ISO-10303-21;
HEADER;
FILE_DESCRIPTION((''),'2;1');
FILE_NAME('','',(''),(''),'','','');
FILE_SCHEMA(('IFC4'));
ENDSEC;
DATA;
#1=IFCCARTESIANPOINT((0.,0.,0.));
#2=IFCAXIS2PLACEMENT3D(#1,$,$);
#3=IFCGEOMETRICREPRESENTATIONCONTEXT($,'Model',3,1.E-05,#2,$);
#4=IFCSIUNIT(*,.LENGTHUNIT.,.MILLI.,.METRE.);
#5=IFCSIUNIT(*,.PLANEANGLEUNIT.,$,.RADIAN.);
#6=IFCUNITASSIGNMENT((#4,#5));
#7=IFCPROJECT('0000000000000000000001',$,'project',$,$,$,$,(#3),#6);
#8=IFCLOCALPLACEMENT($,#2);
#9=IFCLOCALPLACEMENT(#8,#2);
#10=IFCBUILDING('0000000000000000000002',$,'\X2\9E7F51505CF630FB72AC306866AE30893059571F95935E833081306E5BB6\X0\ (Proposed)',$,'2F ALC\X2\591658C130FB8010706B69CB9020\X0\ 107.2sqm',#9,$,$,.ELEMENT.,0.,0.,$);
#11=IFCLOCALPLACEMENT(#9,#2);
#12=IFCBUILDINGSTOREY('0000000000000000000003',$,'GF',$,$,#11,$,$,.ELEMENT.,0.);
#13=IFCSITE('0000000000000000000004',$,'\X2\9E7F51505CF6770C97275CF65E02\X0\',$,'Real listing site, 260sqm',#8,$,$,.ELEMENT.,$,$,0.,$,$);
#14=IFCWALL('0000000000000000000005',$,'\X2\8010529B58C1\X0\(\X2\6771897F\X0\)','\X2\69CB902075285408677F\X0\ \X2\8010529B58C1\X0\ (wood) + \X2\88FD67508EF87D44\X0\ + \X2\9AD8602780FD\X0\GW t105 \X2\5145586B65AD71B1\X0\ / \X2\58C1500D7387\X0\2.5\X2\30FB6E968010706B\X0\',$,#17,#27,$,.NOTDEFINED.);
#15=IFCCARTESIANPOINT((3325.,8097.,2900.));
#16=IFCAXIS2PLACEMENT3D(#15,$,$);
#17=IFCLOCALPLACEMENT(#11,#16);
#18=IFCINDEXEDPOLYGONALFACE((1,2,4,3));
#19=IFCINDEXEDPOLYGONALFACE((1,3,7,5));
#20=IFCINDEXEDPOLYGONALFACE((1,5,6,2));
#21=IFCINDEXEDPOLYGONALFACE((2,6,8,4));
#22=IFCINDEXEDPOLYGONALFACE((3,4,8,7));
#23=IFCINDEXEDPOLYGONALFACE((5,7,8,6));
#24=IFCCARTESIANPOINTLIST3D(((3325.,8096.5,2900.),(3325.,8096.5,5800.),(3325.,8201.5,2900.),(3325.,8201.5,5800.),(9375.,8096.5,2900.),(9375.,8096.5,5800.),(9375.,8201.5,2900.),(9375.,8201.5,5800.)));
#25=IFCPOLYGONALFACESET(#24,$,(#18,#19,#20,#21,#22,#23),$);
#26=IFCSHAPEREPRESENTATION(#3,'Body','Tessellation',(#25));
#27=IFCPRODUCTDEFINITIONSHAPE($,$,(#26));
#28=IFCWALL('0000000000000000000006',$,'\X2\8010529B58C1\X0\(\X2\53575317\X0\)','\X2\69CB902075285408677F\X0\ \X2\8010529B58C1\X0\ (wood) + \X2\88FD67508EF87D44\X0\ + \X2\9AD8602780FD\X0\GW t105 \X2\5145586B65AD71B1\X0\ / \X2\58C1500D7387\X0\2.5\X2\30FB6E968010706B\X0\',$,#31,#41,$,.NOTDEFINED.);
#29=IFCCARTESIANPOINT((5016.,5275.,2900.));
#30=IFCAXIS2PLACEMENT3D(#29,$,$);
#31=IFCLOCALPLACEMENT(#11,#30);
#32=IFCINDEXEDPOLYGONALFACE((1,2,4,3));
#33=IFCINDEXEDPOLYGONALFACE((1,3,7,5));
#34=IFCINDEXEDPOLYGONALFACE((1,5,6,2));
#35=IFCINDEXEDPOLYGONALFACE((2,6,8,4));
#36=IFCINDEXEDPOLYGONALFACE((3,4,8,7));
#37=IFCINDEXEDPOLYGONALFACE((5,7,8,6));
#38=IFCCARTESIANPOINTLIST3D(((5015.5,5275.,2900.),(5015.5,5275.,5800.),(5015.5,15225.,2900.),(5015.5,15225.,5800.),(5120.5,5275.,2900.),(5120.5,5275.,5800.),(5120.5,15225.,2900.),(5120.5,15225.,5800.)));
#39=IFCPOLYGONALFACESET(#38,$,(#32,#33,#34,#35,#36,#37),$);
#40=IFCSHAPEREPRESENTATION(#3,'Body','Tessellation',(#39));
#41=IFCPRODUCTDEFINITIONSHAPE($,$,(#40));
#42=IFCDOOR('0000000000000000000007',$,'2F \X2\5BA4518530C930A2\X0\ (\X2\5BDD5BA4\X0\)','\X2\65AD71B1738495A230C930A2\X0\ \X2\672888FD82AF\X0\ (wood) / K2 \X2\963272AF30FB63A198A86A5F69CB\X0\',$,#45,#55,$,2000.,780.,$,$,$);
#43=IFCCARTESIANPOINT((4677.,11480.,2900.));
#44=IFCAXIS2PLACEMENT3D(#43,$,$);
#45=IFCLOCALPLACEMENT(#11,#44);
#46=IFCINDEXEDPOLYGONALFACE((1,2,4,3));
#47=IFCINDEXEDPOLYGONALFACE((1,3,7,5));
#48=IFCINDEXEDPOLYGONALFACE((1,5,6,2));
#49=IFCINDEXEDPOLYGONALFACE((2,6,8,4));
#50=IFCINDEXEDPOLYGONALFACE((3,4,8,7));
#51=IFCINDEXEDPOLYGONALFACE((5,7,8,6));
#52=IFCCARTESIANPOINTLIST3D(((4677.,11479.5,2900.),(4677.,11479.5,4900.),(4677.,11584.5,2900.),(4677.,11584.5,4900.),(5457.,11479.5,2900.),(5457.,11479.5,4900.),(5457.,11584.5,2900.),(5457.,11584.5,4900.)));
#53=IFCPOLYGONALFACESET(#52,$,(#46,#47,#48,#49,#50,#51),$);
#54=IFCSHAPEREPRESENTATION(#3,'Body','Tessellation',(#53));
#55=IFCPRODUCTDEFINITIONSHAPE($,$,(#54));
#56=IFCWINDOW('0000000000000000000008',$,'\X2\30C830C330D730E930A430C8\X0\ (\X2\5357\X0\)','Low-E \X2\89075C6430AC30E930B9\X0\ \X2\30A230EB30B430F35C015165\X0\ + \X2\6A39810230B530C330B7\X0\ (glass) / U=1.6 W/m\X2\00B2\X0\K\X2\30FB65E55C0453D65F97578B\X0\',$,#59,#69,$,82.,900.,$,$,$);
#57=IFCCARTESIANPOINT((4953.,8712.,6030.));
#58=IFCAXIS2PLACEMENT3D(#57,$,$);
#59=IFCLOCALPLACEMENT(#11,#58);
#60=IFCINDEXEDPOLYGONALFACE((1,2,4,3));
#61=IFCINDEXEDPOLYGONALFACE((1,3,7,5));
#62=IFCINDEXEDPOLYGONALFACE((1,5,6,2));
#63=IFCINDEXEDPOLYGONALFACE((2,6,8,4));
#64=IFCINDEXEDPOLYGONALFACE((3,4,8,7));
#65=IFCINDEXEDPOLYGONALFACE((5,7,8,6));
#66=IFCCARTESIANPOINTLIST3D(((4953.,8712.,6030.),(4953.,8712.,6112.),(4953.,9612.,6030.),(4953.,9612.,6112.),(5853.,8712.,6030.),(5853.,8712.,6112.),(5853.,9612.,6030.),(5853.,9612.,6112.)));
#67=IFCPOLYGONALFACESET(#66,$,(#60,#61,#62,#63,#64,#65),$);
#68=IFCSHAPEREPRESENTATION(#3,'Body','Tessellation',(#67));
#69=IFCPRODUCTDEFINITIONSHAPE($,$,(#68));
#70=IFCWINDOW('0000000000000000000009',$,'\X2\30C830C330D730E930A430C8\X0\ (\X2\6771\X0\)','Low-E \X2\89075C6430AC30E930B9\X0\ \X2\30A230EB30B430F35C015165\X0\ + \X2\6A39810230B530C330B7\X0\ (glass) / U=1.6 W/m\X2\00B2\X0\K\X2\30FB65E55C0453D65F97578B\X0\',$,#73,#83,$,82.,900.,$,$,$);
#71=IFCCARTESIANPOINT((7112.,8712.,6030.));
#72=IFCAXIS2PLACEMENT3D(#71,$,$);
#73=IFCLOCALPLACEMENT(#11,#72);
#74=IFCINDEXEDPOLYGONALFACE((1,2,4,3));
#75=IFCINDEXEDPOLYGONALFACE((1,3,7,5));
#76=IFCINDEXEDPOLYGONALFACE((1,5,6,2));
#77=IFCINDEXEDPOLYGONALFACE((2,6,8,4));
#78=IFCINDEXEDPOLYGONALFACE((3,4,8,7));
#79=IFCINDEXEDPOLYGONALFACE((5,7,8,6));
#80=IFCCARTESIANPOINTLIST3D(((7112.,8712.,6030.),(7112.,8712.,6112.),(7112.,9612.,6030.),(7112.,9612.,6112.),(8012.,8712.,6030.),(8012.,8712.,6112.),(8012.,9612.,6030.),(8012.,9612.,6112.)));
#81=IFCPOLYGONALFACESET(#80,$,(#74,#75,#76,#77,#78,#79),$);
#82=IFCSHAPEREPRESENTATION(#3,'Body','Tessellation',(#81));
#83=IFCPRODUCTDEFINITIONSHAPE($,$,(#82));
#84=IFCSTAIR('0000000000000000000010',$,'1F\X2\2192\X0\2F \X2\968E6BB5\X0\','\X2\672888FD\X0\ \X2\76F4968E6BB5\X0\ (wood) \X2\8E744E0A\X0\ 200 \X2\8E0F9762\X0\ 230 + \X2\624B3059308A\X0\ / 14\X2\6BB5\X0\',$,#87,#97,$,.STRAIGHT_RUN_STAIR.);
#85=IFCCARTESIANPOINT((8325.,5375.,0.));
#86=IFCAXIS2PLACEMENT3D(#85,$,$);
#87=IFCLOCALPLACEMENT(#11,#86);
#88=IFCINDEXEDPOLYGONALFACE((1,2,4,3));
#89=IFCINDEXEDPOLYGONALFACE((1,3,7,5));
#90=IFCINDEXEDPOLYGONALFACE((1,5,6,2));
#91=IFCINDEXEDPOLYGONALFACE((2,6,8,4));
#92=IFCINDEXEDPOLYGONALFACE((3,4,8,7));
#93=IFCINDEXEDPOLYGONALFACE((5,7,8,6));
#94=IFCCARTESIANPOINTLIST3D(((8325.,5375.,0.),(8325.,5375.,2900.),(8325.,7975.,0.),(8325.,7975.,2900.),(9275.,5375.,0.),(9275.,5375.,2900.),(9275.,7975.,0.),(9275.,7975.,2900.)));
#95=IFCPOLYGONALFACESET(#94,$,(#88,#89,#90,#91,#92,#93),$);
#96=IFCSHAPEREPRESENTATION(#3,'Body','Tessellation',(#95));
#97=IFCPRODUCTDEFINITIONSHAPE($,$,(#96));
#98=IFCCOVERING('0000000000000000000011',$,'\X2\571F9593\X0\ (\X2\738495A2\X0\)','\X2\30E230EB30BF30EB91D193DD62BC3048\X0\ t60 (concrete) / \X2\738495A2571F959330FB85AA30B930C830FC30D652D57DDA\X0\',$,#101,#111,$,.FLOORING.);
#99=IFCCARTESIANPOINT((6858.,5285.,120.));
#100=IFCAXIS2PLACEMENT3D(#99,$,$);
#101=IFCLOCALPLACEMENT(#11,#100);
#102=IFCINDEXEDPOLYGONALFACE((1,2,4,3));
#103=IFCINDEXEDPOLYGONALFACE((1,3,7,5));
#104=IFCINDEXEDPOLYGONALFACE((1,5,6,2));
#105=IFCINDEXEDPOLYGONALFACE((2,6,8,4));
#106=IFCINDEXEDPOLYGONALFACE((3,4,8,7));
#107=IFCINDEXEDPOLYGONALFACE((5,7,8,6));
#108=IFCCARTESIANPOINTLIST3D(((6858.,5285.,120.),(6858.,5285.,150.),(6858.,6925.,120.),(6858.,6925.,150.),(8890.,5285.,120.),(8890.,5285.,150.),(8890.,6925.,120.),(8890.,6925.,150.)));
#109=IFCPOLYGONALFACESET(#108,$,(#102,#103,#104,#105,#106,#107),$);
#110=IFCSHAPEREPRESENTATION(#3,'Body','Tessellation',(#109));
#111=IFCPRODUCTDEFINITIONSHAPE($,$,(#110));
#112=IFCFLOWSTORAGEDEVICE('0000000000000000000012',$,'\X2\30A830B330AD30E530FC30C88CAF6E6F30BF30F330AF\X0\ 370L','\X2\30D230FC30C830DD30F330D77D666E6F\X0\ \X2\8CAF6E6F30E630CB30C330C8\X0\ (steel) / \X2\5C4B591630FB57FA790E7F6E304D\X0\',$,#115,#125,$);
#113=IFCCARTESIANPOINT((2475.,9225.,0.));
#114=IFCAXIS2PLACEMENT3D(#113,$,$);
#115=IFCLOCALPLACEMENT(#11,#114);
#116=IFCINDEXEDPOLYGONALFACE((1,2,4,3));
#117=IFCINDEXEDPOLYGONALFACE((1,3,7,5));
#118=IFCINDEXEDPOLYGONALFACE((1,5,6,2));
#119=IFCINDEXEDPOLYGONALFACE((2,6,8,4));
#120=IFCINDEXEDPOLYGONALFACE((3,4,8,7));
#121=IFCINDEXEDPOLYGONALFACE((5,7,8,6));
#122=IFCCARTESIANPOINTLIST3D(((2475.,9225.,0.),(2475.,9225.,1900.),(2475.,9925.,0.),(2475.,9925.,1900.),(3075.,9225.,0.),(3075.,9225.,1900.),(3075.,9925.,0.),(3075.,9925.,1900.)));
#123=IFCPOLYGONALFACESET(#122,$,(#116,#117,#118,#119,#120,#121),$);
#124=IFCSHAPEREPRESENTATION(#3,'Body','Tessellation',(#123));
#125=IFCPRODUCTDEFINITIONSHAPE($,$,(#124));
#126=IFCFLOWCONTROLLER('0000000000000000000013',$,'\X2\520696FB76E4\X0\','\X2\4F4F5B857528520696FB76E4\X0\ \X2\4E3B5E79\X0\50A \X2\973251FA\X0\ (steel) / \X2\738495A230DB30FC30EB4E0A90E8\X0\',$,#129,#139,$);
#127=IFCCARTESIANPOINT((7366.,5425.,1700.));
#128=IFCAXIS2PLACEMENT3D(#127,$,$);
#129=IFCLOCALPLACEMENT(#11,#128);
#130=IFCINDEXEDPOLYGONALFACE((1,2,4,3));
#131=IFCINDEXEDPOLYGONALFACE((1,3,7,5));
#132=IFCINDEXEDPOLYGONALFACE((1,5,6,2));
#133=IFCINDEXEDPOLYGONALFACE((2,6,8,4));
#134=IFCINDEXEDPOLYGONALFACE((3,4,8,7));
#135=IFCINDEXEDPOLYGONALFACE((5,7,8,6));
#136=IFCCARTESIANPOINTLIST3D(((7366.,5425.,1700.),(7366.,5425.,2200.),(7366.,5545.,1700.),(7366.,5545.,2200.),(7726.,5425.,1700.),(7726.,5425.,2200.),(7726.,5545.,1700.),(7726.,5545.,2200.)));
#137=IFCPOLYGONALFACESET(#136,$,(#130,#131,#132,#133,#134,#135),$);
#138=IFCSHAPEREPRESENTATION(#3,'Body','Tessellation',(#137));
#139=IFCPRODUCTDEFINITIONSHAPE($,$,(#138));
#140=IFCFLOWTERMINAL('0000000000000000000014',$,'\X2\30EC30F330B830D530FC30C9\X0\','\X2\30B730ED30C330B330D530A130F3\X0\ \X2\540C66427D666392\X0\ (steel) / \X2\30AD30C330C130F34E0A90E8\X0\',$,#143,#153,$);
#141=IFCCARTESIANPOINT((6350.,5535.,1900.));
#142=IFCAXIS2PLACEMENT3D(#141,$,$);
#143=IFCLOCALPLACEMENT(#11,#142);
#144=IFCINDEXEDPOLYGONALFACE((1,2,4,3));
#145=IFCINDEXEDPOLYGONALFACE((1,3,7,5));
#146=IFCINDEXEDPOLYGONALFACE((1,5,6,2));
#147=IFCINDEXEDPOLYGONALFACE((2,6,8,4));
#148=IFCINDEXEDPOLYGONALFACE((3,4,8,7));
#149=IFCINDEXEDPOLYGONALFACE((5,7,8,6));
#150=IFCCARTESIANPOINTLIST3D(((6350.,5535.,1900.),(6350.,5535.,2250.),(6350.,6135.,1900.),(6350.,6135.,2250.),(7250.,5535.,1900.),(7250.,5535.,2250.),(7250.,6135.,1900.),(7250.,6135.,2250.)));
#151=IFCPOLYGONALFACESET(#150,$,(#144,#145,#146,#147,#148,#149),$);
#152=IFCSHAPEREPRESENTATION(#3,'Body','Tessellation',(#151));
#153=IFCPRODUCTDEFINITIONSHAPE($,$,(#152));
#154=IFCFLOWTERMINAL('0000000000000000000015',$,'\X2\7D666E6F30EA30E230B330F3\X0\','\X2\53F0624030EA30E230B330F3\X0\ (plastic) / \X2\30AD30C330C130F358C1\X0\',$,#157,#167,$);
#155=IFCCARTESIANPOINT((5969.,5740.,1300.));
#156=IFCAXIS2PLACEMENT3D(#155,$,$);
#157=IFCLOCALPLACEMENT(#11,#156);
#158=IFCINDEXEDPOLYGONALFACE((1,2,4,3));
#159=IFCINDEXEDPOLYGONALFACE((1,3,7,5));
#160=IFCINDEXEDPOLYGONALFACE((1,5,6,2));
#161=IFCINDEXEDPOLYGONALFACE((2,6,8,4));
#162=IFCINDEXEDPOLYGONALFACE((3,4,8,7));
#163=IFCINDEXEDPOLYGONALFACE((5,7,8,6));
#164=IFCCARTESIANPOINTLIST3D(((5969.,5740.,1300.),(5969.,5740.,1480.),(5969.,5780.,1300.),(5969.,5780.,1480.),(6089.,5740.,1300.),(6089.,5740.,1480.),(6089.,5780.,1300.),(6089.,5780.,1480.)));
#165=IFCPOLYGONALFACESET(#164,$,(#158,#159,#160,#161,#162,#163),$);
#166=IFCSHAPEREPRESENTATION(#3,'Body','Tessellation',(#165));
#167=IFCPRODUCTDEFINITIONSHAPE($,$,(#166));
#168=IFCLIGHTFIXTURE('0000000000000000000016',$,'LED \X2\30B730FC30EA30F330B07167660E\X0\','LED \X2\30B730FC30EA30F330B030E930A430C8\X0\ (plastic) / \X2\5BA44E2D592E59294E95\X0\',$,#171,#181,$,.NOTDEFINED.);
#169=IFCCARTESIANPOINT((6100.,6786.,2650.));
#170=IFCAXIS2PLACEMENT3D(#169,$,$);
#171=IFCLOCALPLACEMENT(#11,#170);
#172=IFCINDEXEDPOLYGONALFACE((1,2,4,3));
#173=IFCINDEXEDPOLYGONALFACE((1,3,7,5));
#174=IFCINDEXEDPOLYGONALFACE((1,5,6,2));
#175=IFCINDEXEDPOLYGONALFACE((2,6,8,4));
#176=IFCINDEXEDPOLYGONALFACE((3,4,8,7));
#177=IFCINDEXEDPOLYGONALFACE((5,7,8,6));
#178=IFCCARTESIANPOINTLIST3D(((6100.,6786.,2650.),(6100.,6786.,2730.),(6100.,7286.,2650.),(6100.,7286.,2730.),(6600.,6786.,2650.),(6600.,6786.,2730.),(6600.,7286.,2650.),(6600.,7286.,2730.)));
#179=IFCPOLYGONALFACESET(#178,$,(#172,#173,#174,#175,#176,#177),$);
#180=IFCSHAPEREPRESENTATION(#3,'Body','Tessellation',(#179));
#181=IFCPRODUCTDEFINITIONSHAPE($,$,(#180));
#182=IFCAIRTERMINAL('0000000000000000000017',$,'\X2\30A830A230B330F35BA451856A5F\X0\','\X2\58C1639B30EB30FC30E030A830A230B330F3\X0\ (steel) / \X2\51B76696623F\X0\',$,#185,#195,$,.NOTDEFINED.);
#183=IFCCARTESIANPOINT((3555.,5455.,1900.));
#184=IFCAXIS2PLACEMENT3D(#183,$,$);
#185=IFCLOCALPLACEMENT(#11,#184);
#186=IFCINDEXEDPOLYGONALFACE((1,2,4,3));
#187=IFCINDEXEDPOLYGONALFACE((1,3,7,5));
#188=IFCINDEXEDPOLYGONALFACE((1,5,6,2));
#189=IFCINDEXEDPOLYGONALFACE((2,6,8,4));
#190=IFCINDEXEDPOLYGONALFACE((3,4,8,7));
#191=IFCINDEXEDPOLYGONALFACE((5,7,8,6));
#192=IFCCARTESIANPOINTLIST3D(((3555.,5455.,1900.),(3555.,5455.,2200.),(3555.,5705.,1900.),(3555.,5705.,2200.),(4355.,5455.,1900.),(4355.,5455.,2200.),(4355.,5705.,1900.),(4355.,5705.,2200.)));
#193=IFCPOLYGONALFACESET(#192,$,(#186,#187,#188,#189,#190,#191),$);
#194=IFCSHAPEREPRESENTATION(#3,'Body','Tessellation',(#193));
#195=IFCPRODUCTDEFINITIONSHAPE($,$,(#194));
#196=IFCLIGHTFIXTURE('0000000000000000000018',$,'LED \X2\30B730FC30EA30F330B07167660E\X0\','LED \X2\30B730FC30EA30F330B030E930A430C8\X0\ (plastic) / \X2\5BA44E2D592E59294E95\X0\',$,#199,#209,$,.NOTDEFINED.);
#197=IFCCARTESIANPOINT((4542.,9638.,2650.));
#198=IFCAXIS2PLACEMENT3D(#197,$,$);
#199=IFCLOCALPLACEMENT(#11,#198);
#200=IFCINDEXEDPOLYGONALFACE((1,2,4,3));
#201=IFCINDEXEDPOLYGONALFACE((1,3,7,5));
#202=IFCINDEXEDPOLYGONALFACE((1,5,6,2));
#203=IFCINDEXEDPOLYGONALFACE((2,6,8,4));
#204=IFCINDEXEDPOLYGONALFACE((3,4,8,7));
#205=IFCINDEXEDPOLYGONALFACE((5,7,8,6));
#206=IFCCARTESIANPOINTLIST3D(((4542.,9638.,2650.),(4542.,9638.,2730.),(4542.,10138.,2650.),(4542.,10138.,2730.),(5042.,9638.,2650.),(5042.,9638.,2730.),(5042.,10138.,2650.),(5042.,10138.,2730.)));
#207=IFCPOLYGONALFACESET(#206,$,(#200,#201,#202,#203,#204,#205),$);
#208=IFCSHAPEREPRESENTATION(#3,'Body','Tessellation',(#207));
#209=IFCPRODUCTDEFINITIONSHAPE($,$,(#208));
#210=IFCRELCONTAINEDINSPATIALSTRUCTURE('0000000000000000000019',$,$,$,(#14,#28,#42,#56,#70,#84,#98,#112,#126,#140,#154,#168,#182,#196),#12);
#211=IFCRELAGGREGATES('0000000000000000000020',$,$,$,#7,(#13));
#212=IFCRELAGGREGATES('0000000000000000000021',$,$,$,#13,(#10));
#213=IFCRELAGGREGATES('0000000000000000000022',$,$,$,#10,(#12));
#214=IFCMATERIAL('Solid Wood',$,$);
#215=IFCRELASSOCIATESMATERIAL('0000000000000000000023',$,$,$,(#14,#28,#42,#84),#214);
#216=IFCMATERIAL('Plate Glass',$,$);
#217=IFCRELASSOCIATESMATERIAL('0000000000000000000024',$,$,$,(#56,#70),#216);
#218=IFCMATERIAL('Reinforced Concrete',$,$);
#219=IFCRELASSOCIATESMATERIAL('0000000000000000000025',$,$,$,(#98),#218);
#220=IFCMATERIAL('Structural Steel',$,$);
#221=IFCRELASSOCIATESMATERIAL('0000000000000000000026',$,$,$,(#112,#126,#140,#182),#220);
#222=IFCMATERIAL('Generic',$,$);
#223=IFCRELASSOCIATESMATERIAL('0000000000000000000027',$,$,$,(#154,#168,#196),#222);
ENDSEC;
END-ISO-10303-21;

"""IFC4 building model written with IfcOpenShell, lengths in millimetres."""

from ifc_helpers import new_model, si_unit, frame, frame_2d, origin, place, context, project, spatial, rectangle, extrude, material, element, fill, save


model = new_model("IFC4")

# Units and contexts
model_context = context("Model", 3, precision=1e-05, world=origin())
ifc_project = project(units=[si_unit("LENGTHUNIT", "METRE", prefix="MILLI"), si_unit("PLANEANGLEUNIT", "RADIAN")], contexts=[model_context])

# Site, building, storey
site_placement = place(None, origin())
site = spatial("IfcSite", under=ifc_project, at=site_placement, Name="鹿児島県霧島市", ObjectType="Real listing site, 260sqm", CompositionType="ELEMENT", RefElevation=0.0)
building_placement = place(site_placement, origin())
building = spatial("IfcBuilding", under=site, at=building_placement, Name="鹿児島・犬と暮らす土間広めの家 (Proposed)", ObjectType="2F ALC外壁・耐火構造 107.2sqm", CompositionType="ELEMENT", ElevationOfRefHeight=0.0, ElevationOfTerrain=0.0)
storey_placement = place(building_placement, origin())
storey = spatial("IfcBuildingStorey", under=building, at=storey_placement, Name="GF", CompositionType="ELEMENT", Elevation=0.0)

# Shared definitions
ifc_material_1 = material(Name="Solid Wood")

# Wall
wall_1_placement = place(storey_placement, frame((3325.0, 8097.0, 2900.0)))
element("IfcWall", 1, at=wall_1_placement, inside=storey, material=ifc_material_1, Name="耐力壁(東西)", Description="構造用合板 耐力壁 (wood) + 製材軸組 + 高性能GW t105 充填断熱 / 壁倍率2.5・準耐火", PredefinedType="NOTDEFINED", context=model_context, shape_type="SweptSolid", body=[
    extrude(rectangle(XDim=6050.0, YDim=105.0, at=frame_2d((3025.0, 52.0))), frame((3325.0, 8097.0, 2900.0)), (0.0, 0.0, 1.0), 2900.0),
])

# Wall, opening, door
wall_2_placement = place(storey_placement, frame((5016.0, 5275.0, 2900.0)))
wall_2 = element("IfcWall", 2, at=wall_2_placement, inside=storey, material=ifc_material_1, Name="耐力壁(南北)", Description="構造用合板 耐力壁 (wood) + 製材軸組 + 高性能GW t105 充填断熱 / 壁倍率2.5・準耐火", PredefinedType="NOTDEFINED", context=model_context, shape_type="SweptSolid", body=[
    extrude(rectangle(XDim=105.0, YDim=9950.0, at=frame_2d((52.0, 4975.0))), frame((5016.0, 5275.0, 2900.0)), (0.0, 0.0, 1.0), 2900.0),
])
opening_placement = place(storey_placement, frame((4677.0, 11480.0, 2900.0)))
opening = element("IfcOpeningElement", 3, at=opening_placement, cuts=wall_2, PredefinedType="NOTDEFINED", context=model_context, shape_type="SweptSolid", body=[
    extrude(rectangle(XDim=780.0, YDim=105.0, at=frame_2d((390.0, 52.0))), frame((4677.0, 11480.0, 2900.0)), (0.0, 0.0, 1.0), 2000.0),
])
door_placement = place(storey_placement, frame((4677.0, 11480.0, 2900.0)))
door = element("IfcDoor", 4, at=door_placement, inside=storey, material=ifc_material_1, Name="2F 室内ドア (寝室)", Description="断熱玄関ドア 木製芯 (wood) / K2 防犯・採風機構", OverallHeight=2000.0, OverallWidth=780.0, context=model_context, shape_type="SweptSolid", body=[
    extrude(rectangle(XDim=780.0, YDim=105.0, at=frame_2d((390.0, 52.0))), frame((4677.0, 11480.0, 2900.0)), (0.0, 0.0, 1.0), 2000.0),
])
fill(opening, door)

# Windows
ifc_material_2 = material(Name="Plate Glass")
window_1_placement = place(storey_placement, frame((4953.0, 8712.0, 6030.0)))
element("IfcWindow", 5, at=window_1_placement, inside=storey, material=ifc_material_2, Name="トップライト (南)", Description="Low-E 複層ガラス アルゴン封入 + 樹脂サッシ (glass) / U=1.6 W/m²K・日射取得型", OverallHeight=82.0, OverallWidth=900.0, context=model_context, shape_type="SweptSolid", body=[
    extrude(rectangle(XDim=900.0, YDim=900.0, at=frame_2d((450.0, 450.0))), frame((4953.0, 8712.0, 6030.0)), (0.0, 0.0, 1.0), 82.0),
])
window_2_placement = place(storey_placement, frame((7112.0, 8712.0, 6030.0)))
element("IfcWindow", 6, at=window_2_placement, inside=storey, material=ifc_material_2, Name="トップライト (東)", Description="Low-E 複層ガラス アルゴン封入 + 樹脂サッシ (glass) / U=1.6 W/m²K・日射取得型", OverallHeight=82.0, OverallWidth=900.0, context=model_context, shape_type="SweptSolid", body=[
    extrude(rectangle(XDim=900.0, YDim=900.0, at=frame_2d((450.0, 450.0))), frame((7112.0, 8712.0, 6030.0)), (0.0, 0.0, 1.0), 82.0),
])

# Stair
stair_placement = place(storey_placement, frame((8325.0, 5375.0, 0.0)))
element("IfcStair", 7, at=stair_placement, inside=storey, material=ifc_material_1, Name="1F→2F 階段", Description="木製 直階段 (wood) 蹴上 200 踏面 230 + 手すり / 14段", PredefinedType="STRAIGHT_RUN_STAIR", context=model_context, shape_type="SweptSolid", body=[
    extrude(rectangle(XDim=950.0, YDim=2600.0, at=frame_2d((475.0, 1300.0))), frame((8325.0, 5375.0, 0.0)), (0.0, 0.0, 1.0), 2900.0),
])

# Covering
ifc_material_3 = material(Name="Reinforced Concrete")
covering_placement = place(storey_placement, frame((6858.0, 5285.0, 120.0)))
element("IfcCovering", 8, at=covering_placement, inside=storey, material=ifc_material_3, Name="土間 (玄関)", Description="モルタル金鏝押え t60 (concrete) / 玄関土間・薪ストーブ動線", PredefinedType="FLOORING", context=model_context, shape_type="SweptSolid", body=[
    extrude(rectangle(XDim=2032.0, YDim=1640.0, at=frame_2d((1016.0, 820.0))), frame((6858.0, 5285.0, 120.0)), (0.0, 0.0, 1.0), 30.0),
])

# Flow storage device
ifc_material_4 = material(Name="Structural Steel")
flow_storage_device_placement = place(storey_placement, frame((2475.0, 9225.0, 0.0)))
element("IfcFlowStorageDevice", 9, at=flow_storage_device_placement, inside=storey, material=ifc_material_4, Name="エコキュート貯湯タンク 370L", Description="ヒートポンプ給湯 貯湯ユニット (steel) / 屋外・基礎置き", context=model_context, shape_type="SweptSolid", body=[
    extrude(rectangle(XDim=600.0, YDim=700.0, at=frame_2d((300.0, 350.0))), frame((2475.0, 9225.0, 0.0)), (0.0, 0.0, 1.0), 1900.0),
])

# Flow controller
flow_controller_placement = place(storey_placement, frame((7366.0, 5425.0, 1700.0)))
element("IfcFlowController", 10, at=flow_controller_placement, inside=storey, material=ifc_material_4, Name="分電盤", Description="住宅用分電盤 主幹50A 露出 (steel) / 玄関ホール上部", context=model_context, shape_type="SweptSolid", body=[
    extrude(rectangle(XDim=360.0, YDim=120.0, at=frame_2d((180.0, 60.0))), frame((7366.0, 5425.0, 1700.0)), (0.0, 0.0, 1.0), 500.0),
])

# Flow terminals
flow_terminal_1_placement = place(storey_placement, frame((6350.0, 5535.0, 1900.0)))
element("IfcFlowTerminal", 11, at=flow_terminal_1_placement, inside=storey, material=ifc_material_4, Name="レンジフード", Description="シロッコファン 同時給排 (steel) / キッチン上部", context=model_context, shape_type="SweptSolid", body=[
    extrude(rectangle(XDim=900.0, YDim=600.0, at=frame_2d((450.0, 300.0))), frame((6350.0, 5535.0, 1900.0)), (0.0, 0.0, 1.0), 350.0),
])
ifc_material_5 = material(Name="Generic")
flow_terminal_2_placement = place(storey_placement, frame((5969.0, 5740.0, 1300.0)))
element("IfcFlowTerminal", 12, at=flow_terminal_2_placement, inside=storey, material=ifc_material_5, Name="給湯リモコン", Description="台所リモコン (plastic) / キッチン壁", context=model_context, shape_type="SweptSolid", body=[
    extrude(rectangle(XDim=120.0, YDim=40.0, at=frame_2d((60.0, 20.0))), frame((5969.0, 5740.0, 1300.0)), (0.0, 0.0, 1.0), 180.0),
])

# Light fixture
light_fixture_1_placement = place(storey_placement, frame((6100.0, 6786.0, 2650.0)))
element("IfcLightFixture", 13, at=light_fixture_1_placement, inside=storey, material=ifc_material_5, Name="LED シーリング照明", Description="LED シーリングライト (plastic) / 室中央天井", PredefinedType="NOTDEFINED", context=model_context, shape_type="SweptSolid", body=[
    extrude(rectangle(XDim=500.0, YDim=500.0, at=frame_2d((250.0, 250.0))), frame((6100.0, 6786.0, 2650.0)), (0.0, 0.0, 1.0), 80.0),
])

# Air terminal
air_terminal_1_placement = place(storey_placement, frame((3555.0, 5455.0, 1900.0)))
element("IfcAirTerminal", 14, at=air_terminal_1_placement, inside=storey, material=ifc_material_4, Name="エアコン室内機", Description="壁掛ルームエアコン (steel) / 冷暖房", PredefinedType="NOTDEFINED", context=model_context, shape_type="SweptSolid", body=[
    extrude(rectangle(XDim=800.0, YDim=250.0, at=frame_2d((400.0, 125.0))), frame((3555.0, 5455.0, 1900.0)), (0.0, 0.0, 1.0), 300.0),
])

# Light fixture
light_fixture_2_placement = place(storey_placement, frame((4542.0, 9638.0, 2650.0)))
element("IfcLightFixture", 15, at=light_fixture_2_placement, inside=storey, material=ifc_material_5, Name="LED シーリング照明", Description="LED シーリングライト (plastic) / 室中央天井", PredefinedType="NOTDEFINED", context=model_context, shape_type="SweptSolid", body=[
    extrude(rectangle(XDim=500.0, YDim=500.0, at=frame_2d((250.0, 250.0))), frame((4542.0, 9638.0, 2650.0)), (0.0, 0.0, 1.0), 80.0),
])

save(model, "model.ifc")
